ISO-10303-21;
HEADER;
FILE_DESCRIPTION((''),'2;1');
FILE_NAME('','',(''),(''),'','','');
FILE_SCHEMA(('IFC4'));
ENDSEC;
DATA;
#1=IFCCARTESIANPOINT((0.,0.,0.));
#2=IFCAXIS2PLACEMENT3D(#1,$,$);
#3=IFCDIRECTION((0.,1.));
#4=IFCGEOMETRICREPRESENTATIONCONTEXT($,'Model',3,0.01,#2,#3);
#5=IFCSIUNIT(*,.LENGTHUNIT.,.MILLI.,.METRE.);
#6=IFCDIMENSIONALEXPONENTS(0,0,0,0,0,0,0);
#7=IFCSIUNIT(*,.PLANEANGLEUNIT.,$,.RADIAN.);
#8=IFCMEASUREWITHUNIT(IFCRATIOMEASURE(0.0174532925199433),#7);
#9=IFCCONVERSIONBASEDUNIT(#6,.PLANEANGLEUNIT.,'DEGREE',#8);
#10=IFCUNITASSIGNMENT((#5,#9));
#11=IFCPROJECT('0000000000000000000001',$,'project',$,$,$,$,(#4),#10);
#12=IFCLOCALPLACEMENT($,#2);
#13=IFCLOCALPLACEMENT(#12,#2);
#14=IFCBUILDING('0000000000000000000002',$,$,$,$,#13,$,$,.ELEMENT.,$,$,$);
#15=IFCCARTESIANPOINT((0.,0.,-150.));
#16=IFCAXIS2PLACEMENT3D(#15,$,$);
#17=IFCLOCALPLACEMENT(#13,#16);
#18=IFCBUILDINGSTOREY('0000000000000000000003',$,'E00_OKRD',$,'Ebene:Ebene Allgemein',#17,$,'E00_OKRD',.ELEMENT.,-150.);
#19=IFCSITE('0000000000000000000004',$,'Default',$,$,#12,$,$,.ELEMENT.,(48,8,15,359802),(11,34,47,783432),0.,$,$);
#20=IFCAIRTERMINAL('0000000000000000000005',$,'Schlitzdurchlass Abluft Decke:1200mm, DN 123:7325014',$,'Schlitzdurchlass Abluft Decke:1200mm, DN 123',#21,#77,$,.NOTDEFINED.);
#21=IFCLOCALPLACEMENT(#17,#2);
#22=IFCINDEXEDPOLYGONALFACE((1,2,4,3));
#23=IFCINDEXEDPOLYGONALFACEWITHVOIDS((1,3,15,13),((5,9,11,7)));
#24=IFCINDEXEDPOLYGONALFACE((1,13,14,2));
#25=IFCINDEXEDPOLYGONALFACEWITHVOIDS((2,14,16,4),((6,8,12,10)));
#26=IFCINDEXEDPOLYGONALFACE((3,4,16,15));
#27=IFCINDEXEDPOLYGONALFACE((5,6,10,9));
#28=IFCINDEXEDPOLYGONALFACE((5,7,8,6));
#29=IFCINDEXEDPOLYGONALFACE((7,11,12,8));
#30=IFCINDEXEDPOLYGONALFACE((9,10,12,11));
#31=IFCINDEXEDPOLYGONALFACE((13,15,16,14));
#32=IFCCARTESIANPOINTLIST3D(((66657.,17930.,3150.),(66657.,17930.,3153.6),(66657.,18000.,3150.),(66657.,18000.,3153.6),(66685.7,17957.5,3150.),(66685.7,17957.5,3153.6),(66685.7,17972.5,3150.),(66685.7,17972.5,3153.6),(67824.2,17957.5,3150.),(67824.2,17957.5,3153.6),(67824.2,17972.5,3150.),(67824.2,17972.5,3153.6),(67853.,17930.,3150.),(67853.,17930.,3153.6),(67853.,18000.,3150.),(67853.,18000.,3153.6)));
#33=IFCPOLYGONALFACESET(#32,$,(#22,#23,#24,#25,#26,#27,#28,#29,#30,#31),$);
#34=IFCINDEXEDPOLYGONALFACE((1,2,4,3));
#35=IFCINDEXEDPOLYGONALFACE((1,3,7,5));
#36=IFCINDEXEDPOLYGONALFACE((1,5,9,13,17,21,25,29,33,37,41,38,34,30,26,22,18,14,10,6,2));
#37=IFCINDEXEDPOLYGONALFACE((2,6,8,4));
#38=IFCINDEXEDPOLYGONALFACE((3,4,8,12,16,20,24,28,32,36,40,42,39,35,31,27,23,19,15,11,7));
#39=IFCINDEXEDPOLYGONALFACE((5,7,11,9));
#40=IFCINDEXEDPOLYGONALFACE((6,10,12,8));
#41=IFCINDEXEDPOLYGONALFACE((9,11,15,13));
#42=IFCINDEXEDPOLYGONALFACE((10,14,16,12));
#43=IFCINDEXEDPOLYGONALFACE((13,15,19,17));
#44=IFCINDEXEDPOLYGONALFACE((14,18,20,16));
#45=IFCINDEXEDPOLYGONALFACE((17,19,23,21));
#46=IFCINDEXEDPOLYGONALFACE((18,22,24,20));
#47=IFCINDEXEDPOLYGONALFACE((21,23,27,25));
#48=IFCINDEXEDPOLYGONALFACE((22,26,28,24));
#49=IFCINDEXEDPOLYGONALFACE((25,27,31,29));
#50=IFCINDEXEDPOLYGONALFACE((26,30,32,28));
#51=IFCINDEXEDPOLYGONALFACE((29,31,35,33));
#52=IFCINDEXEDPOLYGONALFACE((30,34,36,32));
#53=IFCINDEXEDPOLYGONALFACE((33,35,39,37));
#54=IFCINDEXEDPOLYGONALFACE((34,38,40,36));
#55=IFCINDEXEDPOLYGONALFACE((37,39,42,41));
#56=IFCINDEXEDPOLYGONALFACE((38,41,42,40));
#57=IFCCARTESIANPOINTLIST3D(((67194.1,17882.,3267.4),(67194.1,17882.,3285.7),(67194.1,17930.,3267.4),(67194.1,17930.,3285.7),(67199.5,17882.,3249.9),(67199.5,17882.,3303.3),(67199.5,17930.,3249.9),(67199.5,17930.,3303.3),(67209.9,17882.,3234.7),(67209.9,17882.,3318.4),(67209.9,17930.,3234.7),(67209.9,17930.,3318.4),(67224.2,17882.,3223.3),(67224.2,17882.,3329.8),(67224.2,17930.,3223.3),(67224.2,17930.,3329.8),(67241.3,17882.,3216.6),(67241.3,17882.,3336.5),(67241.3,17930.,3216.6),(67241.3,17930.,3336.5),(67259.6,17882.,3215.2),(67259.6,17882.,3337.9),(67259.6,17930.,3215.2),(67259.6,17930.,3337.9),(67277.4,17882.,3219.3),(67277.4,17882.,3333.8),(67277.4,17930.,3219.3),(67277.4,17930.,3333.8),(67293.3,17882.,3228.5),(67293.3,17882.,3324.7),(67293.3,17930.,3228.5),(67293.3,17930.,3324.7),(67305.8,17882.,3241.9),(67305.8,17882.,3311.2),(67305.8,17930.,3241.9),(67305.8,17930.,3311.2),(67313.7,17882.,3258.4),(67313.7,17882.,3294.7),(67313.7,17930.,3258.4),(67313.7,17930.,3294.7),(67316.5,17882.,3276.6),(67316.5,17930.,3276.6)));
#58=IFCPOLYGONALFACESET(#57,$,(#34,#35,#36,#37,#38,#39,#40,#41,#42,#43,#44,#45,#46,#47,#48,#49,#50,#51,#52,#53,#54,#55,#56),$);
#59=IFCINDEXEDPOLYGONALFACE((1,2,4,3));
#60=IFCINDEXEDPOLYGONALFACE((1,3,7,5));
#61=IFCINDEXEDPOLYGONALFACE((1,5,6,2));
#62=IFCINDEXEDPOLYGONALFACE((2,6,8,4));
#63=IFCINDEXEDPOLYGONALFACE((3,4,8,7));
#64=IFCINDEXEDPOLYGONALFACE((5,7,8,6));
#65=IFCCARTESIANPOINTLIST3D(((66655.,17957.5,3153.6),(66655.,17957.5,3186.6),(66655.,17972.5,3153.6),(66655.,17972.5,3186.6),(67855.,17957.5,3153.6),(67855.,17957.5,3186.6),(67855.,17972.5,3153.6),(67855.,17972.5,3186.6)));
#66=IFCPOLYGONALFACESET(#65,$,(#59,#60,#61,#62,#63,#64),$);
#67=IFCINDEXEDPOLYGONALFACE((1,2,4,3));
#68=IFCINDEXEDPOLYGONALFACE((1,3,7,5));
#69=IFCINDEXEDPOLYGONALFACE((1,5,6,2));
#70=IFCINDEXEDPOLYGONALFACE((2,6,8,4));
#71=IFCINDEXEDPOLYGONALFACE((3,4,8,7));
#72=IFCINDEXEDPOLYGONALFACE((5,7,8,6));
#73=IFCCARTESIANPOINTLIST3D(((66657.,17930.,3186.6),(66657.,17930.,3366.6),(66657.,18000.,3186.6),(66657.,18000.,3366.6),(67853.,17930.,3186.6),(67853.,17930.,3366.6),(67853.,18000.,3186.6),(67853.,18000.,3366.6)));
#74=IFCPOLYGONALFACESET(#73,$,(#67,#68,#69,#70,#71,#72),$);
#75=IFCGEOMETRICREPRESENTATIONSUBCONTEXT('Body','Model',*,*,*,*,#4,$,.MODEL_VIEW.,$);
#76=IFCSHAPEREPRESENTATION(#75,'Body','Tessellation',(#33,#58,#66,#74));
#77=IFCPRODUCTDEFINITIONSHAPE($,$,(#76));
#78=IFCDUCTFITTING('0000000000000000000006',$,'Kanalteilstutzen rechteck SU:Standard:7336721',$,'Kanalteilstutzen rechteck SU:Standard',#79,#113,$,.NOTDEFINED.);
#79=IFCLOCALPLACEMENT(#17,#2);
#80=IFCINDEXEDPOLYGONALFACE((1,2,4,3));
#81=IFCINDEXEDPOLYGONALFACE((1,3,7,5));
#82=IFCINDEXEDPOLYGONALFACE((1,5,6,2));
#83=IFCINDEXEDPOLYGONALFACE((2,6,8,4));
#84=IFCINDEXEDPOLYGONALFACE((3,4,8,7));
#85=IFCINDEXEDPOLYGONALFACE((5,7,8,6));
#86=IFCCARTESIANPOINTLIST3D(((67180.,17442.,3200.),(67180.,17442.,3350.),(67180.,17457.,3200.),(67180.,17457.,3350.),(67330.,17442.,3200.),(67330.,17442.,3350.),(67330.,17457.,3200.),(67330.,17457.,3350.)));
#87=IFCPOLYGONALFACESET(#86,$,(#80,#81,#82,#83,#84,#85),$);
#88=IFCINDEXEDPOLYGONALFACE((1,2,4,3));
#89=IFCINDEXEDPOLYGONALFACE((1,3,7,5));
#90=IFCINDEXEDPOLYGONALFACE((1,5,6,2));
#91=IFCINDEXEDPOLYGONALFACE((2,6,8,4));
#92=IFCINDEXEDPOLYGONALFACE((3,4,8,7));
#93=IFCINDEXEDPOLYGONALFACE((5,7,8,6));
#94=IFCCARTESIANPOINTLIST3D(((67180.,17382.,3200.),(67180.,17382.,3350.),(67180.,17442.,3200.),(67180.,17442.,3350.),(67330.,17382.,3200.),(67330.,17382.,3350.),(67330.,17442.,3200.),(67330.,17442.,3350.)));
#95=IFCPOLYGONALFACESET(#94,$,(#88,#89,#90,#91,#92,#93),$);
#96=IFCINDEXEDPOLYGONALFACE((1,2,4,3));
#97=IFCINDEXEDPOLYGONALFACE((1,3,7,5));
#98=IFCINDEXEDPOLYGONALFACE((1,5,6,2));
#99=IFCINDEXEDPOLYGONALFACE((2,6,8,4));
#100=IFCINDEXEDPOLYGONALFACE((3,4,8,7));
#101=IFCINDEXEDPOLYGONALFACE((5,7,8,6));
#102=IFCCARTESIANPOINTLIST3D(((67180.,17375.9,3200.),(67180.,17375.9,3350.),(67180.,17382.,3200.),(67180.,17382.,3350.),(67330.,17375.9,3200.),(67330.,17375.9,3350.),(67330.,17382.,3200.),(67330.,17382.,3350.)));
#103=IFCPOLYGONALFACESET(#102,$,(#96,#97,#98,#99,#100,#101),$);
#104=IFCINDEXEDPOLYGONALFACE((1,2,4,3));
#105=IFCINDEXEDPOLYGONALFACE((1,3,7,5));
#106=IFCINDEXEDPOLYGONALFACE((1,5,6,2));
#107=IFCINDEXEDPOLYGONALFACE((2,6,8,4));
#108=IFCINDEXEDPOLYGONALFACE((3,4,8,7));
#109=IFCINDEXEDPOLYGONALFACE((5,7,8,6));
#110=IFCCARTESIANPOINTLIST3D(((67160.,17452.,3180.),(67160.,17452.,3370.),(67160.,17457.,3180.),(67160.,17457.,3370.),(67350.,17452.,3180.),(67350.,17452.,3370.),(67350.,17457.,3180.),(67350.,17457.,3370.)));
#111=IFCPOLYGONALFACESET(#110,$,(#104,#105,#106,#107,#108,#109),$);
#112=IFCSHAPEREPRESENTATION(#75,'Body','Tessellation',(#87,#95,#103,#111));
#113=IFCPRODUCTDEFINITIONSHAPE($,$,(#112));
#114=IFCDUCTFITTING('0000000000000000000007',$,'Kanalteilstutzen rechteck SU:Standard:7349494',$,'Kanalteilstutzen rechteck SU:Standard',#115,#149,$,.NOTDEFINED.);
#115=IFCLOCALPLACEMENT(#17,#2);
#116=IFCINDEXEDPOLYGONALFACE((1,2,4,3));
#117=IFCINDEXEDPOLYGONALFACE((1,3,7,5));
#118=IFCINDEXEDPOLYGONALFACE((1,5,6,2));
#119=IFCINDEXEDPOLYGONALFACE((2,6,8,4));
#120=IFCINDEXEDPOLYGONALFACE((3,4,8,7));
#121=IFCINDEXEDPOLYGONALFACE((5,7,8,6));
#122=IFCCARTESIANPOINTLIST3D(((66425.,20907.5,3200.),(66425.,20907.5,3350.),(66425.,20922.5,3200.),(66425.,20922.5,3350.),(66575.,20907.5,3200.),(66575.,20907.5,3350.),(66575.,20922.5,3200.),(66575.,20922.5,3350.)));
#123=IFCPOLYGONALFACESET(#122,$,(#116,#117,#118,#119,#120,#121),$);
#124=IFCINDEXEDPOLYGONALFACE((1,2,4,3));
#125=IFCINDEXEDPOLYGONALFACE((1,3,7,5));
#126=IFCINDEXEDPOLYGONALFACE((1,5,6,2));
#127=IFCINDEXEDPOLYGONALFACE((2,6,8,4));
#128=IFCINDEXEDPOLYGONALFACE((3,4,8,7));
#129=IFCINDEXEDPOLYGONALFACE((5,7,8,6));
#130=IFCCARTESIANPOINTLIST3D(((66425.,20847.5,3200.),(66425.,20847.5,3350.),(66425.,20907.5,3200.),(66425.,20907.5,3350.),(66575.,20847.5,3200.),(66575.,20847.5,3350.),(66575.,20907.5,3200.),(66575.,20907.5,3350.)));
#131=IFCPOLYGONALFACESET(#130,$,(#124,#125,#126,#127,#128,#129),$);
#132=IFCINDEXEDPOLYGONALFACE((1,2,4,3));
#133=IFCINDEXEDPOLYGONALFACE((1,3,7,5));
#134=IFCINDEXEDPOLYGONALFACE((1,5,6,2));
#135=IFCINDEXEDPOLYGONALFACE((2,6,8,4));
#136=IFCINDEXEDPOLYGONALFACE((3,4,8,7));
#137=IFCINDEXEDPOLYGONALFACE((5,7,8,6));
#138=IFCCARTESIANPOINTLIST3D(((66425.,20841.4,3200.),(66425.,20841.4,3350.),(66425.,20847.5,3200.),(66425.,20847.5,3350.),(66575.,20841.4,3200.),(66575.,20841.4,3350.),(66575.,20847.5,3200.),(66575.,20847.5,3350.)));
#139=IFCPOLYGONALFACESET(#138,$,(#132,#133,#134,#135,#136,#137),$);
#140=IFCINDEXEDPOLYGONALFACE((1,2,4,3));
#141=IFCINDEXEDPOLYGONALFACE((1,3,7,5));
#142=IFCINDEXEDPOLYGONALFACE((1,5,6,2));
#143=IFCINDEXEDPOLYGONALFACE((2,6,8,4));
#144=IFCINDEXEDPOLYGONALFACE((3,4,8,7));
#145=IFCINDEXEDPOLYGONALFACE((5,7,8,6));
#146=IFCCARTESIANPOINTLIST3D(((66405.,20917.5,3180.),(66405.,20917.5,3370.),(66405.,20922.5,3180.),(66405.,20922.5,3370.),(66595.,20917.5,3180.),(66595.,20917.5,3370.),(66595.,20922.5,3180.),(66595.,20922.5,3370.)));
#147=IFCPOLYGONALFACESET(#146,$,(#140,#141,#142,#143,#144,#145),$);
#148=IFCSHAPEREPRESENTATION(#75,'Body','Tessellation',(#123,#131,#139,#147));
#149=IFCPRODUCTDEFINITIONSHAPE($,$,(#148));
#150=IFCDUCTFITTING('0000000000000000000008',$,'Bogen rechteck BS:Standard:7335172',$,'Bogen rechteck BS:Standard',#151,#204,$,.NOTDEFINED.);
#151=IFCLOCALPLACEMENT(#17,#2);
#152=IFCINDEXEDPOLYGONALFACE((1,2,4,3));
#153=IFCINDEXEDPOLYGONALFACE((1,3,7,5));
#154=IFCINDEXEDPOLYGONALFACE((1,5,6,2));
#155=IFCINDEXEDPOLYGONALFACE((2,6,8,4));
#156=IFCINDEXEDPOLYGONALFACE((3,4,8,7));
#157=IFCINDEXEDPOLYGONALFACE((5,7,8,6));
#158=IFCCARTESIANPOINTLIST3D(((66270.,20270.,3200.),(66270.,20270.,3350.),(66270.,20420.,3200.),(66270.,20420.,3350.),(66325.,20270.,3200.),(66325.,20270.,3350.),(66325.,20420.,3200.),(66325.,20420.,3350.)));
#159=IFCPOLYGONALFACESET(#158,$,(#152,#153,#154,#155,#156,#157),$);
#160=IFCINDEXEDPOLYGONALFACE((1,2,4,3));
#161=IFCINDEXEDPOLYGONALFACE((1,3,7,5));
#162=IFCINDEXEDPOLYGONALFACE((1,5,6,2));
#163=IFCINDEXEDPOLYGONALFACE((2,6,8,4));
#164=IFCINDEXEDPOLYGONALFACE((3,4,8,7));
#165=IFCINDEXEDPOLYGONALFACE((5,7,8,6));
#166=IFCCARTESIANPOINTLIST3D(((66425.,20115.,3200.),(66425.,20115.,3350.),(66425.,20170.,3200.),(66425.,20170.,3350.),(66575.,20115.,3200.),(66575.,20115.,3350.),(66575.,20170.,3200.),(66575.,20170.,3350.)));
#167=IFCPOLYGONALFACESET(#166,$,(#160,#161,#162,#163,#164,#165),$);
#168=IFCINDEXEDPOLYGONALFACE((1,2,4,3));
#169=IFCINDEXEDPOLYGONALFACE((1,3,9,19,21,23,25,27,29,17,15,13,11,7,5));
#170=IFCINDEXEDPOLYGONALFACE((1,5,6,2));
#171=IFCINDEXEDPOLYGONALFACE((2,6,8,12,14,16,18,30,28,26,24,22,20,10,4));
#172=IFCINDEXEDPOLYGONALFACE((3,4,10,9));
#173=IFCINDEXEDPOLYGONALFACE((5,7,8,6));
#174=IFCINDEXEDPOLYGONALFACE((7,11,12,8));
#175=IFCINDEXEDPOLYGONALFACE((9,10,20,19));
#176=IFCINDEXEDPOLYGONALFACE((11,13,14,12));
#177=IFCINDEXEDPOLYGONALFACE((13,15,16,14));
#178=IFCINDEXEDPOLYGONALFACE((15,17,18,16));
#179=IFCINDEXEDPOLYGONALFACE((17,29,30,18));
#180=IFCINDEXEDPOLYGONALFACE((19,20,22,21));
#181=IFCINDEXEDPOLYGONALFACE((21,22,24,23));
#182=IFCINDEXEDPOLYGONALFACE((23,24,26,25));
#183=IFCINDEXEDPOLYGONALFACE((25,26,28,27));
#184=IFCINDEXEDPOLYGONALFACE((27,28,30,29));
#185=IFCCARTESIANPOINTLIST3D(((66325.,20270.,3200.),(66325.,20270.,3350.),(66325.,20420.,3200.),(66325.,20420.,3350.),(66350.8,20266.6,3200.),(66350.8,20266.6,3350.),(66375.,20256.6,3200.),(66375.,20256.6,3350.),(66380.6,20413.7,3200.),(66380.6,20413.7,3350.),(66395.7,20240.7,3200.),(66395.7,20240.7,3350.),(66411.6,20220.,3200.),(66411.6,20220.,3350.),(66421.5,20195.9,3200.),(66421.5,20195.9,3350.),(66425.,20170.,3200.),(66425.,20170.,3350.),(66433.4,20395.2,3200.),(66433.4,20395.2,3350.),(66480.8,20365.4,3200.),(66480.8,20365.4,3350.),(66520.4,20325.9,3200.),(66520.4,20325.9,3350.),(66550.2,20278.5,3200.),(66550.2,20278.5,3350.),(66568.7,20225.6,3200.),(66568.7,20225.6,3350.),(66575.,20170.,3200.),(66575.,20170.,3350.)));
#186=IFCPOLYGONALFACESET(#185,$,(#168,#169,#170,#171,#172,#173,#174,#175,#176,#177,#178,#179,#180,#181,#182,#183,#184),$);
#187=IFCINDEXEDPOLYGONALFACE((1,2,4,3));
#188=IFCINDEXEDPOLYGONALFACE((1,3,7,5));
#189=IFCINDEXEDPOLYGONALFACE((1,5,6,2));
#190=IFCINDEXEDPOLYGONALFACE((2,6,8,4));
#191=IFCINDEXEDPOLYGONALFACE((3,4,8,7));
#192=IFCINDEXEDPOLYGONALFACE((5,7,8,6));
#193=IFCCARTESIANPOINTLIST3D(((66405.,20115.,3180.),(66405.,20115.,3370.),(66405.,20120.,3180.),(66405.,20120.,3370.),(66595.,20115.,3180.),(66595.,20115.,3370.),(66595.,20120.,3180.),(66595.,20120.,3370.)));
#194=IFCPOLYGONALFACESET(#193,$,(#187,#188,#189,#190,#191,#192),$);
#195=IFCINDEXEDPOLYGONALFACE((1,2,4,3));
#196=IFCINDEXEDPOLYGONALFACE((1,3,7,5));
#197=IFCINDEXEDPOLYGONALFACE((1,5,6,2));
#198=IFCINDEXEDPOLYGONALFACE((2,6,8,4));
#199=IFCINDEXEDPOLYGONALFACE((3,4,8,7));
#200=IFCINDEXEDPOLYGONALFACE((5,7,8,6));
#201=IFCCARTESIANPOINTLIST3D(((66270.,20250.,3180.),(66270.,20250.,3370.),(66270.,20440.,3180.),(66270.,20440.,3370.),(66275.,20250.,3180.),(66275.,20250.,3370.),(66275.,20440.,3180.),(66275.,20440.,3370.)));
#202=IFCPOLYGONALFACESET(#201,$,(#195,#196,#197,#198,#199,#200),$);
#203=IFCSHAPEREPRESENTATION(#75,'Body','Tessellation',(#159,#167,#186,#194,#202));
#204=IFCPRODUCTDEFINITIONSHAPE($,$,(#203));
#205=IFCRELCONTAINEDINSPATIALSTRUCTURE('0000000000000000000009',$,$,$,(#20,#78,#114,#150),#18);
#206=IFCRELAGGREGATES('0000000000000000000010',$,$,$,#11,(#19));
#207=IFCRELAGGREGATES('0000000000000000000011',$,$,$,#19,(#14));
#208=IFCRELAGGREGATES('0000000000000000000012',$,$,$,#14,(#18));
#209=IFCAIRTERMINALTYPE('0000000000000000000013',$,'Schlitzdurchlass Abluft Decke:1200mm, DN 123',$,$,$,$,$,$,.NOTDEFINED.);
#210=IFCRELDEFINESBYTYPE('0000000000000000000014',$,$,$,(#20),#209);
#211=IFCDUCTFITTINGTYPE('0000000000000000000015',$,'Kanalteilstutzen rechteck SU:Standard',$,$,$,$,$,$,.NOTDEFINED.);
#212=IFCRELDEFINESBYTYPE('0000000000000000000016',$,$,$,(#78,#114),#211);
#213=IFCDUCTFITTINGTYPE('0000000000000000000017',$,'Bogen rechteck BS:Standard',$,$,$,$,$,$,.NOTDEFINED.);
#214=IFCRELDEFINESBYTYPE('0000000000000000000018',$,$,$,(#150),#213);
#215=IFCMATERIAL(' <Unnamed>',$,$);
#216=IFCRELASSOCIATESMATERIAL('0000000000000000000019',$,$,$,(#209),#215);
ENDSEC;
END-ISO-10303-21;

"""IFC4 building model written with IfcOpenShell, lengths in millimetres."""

from ifc_helpers import new_model, entity, si_unit, converted_unit, direction, frame, frame_2d, origin, origin_2d_with_axis, place, context, subcontext, project, spatial, polyline, circle_curve, parameter, trimmed, segment, composite_curve, rectangle, circle, outline, extrude, source, transform, mapped, material, type_object, type_shapes, element, save


model = new_model("IFC4")

# Units and contexts
model_context = context("Model", 3, precision=0.01, world=origin(), true_north=direction((0.0, 1.0)))
body_context = subcontext(model_context, "Body", "Model", "MODEL_VIEW")
ifc_project = project(units=[si_unit("LENGTHUNIT", "METRE", prefix="MILLI"), converted_unit("PLANEANGLEUNIT", "DEGREE", entity("IfcRatioMeasure", 0.0174532925199433), si_unit("PLANEANGLEUNIT", "RADIAN"), dimensions=[0, 0, 0, 0, 0, 0, 0])], contexts=[model_context])

# Site, building, storey
site_placement = place(None, origin())
site = spatial("IfcSite", under=ifc_project, at=site_placement, Name="Default", CompositionType="ELEMENT", RefLatitude=(48, 8, 15, 359802), RefLongitude=(11, 34, 47, 783432), RefElevation=0.0)
building_placement = place(site_placement, origin())
building = spatial("IfcBuilding", under=site, at=building_placement, CompositionType="ELEMENT")
storey_placement = place(building_placement, frame((0.0, 0.0, -150.0)))
storey = spatial("IfcBuildingStorey", under=building, at=storey_placement, Name="E00_OKRD", ObjectType="Ebene:Ebene Allgemein", LongName="E00_OKRD", CompositionType="ELEMENT", Elevation=-150.0)

# Air terminal
ifc_material_1 = material(Name=" <Unnamed>")
air_terminal_type_1 = type_object("IfcAirTerminalType", Name="Schlitzdurchlass Abluft Decke:1200mm, DN 123", PredefinedType="NOTDEFINED", material=ifc_material_1)
shared_shape_1 = source(origin(), body_context, "Body", "SweptSolid", [
    extrude(outline(polyline([(-598.0, -35.0), (598.0, -35.0), (598.0, 35.0), (-598.0, 35.0), (-598.0, -35.0)]), holes=[polyline([(-569.2, -7.5), (-569.2, 7.5), (569.2, 7.5), (569.2, -7.5), (-569.2, -7.5)])]), frame((0.0, 0.0, 0.0), z_axis=(0.0, 0.0, 1.0), x_axis=(-1.0, 0.0, 0.0)), (0.0, 0.0, 1.0), 3.6),
    extrude(circle(Radius=61.5, at=frame_2d((0.0, 0.0), x_axis=(1.0, 0.0))), frame((0.0, 35.0, 126.6), z_axis=(0.0, 1.0, 0.0), x_axis=(-1.0, 0.0, 0.0)), (0.0, 0.0, 1.0), 48.0),
    extrude(rectangle(XDim=1200.0, YDim=15.0, at=origin_2d_with_axis()), frame((0.0, 0.0, 3.6), z_axis=(0.0, 0.0, 1.0), x_axis=(-1.0, 0.0, 0.0)), (0.0, 0.0, 1.0), 33.0),
    extrude(rectangle(XDim=1196.0, YDim=70.0, at=origin_2d_with_axis()), frame((0.0, 0.0, 36.6), z_axis=(0.0, 0.0, 1.0), x_axis=(-1.0, 0.0, 0.0)), (0.0, 0.0, 1.0), 180.0),
])
type_shapes(air_terminal_type_1, [shared_shape_1])
for number, where, z_axis, x_axis, name in (
    (1, (67255.0, 17965.0, 3150.0), (0.0, 0.0, 1.0), (-1.0, 0.0, 0.0), "Schlitzdurchlass Abluft Decke:1200mm, DN 123:7325014"),
):
    element("IfcAirTerminal", number, at=place(storey_placement, frame(where, z_axis=z_axis, x_axis=x_axis)), inside=storey, type_object=air_terminal_type_1, Name=name, ObjectType="Schlitzdurchlass Abluft Decke:1200mm, DN 123", PredefinedType="NOTDEFINED", context=body_context, shape_type="MappedRepresentation", body=[
        mapped(shared_shape_1, transform((0.0, 0.0, 0.0), scale=1.0)),
    ])

# Duct fittings
duct_fitting_type_1 = type_object("IfcDuctFittingType", Name="Kanalteilstutzen rechteck SU:Standard", PredefinedType="NOTDEFINED")
shared_shape_2 = source(origin(), body_context, "Body", "SweptSolid", [
    extrude(rectangle(XDim=150.0, YDim=15.0, at=origin_2d_with_axis()), frame((67.5, 0.0, -75.0), z_axis=(0.0, 0.0, 1.0), x_axis=(0.0, -1.0, 0.0)), (0.0, 0.0, 1.0), 150.0),
    extrude(rectangle(XDim=150.0, YDim=60.0, at=frame_2d((0.0, 0.0), x_axis=(1.0, 0.0))), frame((30.0, 0.0, -75.0), z_axis=(0.0, 0.0, 1.0), x_axis=(0.0, -1.0, 0.0)), (0.0, 0.0, 1.0), 150.0),
    extrude(rectangle(XDim=150.0, YDim=6.1, at=frame_2d((0.0, 0.0), x_axis=(1.0, 0.0))), frame((-3.0, 0.0, -75.0), z_axis=(0.0, 0.0, 1.0), x_axis=(0.0, -1.0, 0.0)), (0.0, 0.0, 1.0), 150.0),
    extrude(rectangle(XDim=190.0, YDim=5.0, at=origin_2d_with_axis()), frame((72.5, 0.0, -95.0), z_axis=(0.0, 0.0, 1.0), x_axis=(0.0, -1.0, 0.0)), (0.0, 0.0, 1.0), 190.0),
])
type_shapes(duct_fitting_type_1, [shared_shape_2])
for number, where, z_axis, x_axis, name in (
    (2, (67255.0, 17382.0, 3275.0), (0.0, 0.0, -1.0), (0.0, 1.0, 0.0), "Kanalteilstutzen rechteck SU:Standard:7336721"),
    (3, (66500.0, 20847.5, 3275.0), (0.0, 0.0, -1.0), (0.0, 1.0, 0.0), "Kanalteilstutzen rechteck SU:Standard:7349494"),
):
    element("IfcDuctFitting", number, at=place(storey_placement, frame(where, z_axis=z_axis, x_axis=x_axis)), inside=storey, type_object=duct_fitting_type_1, Name=name, ObjectType="Kanalteilstutzen rechteck SU:Standard", PredefinedType="NOTDEFINED", context=body_context, shape_type="MappedRepresentation", body=[
        mapped(shared_shape_2, transform((0.0, 0.0, 0.0), scale=1.0)),
    ])
duct_fitting_type_2 = type_object("IfcDuctFittingType", Name="Bogen rechteck BS:Standard", PredefinedType="NOTDEFINED")
shared_shape_3 = source(origin(), body_context, "Body", "SweptSolid", [
    extrude(rectangle(XDim=55.0, YDim=150.0, at=origin_2d_with_axis()), frame((0.0, 202.5, -75.0), z_axis=(0.0, 0.0, 1.0), x_axis=(0.0, 1.0, 0.0)), (0.0, 0.0, 1.0), 150.0),
    extrude(rectangle(XDim=150.0, YDim=55.0, at=frame_2d((0.0, 0.0), x_axis=(1.0, 0.0))), frame((-202.5, 0.0, -75.0), z_axis=(0.0, 0.0, 1.0), x_axis=(0.0, -1.0, 0.0)), (0.0, 0.0, 1.0), 150.0),
    extrude(outline(composite_curve([segment(polyline([(-162.5, -87.5), (-12.5, -87.5)]), True, "CONTINUOUS"), segment(trimmed(circle_curve(frame_2d((87.5, -87.5), x_axis=(0.0, 1.0)), 100.0), [parameter(0.0)], [parameter(90.0)], True, "PARAMETER"), False, "CONTINUOUS"), segment(polyline([(87.5, 12.5), (87.5, 162.5)]), True, "CONTINUOUS"), segment(trimmed(circle_curve(frame_2d((87.5, -87.5), x_axis=(0.0, 1.0)), 250.0), [parameter(0.0)], [parameter(90.0)], True, "PARAMETER"), True, "CONTINUOUS")], self_intersect=False)), frame((-87.5, 87.5, -75.0), z_axis=(0.0, 0.0, 1.0), x_axis=(-1.0, 0.0, 0.0)), (0.0, 0.0, 1.0), 150.0),
    extrude(rectangle(XDim=5.0, YDim=190.0, at=frame_2d((0.0, 0.0), x_axis=(1.0, 0.0))), frame((-227.5, 0.0, -95.0)), (0.0, 0.0, 1.0), 190.0),
    extrude(rectangle(XDim=5.0, YDim=190.0, at=frame_2d((0.0, 0.0), x_axis=(1.0, 0.0))), frame((0.0, 227.5, -95.0), z_axis=(0.0, 0.0, 1.0), x_axis=(0.0, 1.0, 0.0)), (0.0, 0.0, 1.0), 190.0),
])
type_shapes(duct_fitting_type_2, [shared_shape_3])
duct_fitting_1_placement = place(storey_placement, frame((66500.0, 20345.0, 3275.0), z_axis=(0.0, 0.0, 1.0), x_axis=(0.0, 1.0, 0.0)))
element("IfcDuctFitting", 4, at=duct_fitting_1_placement, inside=storey, type_object=duct_fitting_type_2, Name="Bogen rechteck BS:Standard:7335172", ObjectType="Bogen rechteck BS:Standard", PredefinedType="NOTDEFINED", context=body_context, shape_type="MappedRepresentation", body=[
    mapped(shared_shape_3, transform((0.0, 0.0, 0.0), scale=1.0)),
])

save(model, "model.ifc")
